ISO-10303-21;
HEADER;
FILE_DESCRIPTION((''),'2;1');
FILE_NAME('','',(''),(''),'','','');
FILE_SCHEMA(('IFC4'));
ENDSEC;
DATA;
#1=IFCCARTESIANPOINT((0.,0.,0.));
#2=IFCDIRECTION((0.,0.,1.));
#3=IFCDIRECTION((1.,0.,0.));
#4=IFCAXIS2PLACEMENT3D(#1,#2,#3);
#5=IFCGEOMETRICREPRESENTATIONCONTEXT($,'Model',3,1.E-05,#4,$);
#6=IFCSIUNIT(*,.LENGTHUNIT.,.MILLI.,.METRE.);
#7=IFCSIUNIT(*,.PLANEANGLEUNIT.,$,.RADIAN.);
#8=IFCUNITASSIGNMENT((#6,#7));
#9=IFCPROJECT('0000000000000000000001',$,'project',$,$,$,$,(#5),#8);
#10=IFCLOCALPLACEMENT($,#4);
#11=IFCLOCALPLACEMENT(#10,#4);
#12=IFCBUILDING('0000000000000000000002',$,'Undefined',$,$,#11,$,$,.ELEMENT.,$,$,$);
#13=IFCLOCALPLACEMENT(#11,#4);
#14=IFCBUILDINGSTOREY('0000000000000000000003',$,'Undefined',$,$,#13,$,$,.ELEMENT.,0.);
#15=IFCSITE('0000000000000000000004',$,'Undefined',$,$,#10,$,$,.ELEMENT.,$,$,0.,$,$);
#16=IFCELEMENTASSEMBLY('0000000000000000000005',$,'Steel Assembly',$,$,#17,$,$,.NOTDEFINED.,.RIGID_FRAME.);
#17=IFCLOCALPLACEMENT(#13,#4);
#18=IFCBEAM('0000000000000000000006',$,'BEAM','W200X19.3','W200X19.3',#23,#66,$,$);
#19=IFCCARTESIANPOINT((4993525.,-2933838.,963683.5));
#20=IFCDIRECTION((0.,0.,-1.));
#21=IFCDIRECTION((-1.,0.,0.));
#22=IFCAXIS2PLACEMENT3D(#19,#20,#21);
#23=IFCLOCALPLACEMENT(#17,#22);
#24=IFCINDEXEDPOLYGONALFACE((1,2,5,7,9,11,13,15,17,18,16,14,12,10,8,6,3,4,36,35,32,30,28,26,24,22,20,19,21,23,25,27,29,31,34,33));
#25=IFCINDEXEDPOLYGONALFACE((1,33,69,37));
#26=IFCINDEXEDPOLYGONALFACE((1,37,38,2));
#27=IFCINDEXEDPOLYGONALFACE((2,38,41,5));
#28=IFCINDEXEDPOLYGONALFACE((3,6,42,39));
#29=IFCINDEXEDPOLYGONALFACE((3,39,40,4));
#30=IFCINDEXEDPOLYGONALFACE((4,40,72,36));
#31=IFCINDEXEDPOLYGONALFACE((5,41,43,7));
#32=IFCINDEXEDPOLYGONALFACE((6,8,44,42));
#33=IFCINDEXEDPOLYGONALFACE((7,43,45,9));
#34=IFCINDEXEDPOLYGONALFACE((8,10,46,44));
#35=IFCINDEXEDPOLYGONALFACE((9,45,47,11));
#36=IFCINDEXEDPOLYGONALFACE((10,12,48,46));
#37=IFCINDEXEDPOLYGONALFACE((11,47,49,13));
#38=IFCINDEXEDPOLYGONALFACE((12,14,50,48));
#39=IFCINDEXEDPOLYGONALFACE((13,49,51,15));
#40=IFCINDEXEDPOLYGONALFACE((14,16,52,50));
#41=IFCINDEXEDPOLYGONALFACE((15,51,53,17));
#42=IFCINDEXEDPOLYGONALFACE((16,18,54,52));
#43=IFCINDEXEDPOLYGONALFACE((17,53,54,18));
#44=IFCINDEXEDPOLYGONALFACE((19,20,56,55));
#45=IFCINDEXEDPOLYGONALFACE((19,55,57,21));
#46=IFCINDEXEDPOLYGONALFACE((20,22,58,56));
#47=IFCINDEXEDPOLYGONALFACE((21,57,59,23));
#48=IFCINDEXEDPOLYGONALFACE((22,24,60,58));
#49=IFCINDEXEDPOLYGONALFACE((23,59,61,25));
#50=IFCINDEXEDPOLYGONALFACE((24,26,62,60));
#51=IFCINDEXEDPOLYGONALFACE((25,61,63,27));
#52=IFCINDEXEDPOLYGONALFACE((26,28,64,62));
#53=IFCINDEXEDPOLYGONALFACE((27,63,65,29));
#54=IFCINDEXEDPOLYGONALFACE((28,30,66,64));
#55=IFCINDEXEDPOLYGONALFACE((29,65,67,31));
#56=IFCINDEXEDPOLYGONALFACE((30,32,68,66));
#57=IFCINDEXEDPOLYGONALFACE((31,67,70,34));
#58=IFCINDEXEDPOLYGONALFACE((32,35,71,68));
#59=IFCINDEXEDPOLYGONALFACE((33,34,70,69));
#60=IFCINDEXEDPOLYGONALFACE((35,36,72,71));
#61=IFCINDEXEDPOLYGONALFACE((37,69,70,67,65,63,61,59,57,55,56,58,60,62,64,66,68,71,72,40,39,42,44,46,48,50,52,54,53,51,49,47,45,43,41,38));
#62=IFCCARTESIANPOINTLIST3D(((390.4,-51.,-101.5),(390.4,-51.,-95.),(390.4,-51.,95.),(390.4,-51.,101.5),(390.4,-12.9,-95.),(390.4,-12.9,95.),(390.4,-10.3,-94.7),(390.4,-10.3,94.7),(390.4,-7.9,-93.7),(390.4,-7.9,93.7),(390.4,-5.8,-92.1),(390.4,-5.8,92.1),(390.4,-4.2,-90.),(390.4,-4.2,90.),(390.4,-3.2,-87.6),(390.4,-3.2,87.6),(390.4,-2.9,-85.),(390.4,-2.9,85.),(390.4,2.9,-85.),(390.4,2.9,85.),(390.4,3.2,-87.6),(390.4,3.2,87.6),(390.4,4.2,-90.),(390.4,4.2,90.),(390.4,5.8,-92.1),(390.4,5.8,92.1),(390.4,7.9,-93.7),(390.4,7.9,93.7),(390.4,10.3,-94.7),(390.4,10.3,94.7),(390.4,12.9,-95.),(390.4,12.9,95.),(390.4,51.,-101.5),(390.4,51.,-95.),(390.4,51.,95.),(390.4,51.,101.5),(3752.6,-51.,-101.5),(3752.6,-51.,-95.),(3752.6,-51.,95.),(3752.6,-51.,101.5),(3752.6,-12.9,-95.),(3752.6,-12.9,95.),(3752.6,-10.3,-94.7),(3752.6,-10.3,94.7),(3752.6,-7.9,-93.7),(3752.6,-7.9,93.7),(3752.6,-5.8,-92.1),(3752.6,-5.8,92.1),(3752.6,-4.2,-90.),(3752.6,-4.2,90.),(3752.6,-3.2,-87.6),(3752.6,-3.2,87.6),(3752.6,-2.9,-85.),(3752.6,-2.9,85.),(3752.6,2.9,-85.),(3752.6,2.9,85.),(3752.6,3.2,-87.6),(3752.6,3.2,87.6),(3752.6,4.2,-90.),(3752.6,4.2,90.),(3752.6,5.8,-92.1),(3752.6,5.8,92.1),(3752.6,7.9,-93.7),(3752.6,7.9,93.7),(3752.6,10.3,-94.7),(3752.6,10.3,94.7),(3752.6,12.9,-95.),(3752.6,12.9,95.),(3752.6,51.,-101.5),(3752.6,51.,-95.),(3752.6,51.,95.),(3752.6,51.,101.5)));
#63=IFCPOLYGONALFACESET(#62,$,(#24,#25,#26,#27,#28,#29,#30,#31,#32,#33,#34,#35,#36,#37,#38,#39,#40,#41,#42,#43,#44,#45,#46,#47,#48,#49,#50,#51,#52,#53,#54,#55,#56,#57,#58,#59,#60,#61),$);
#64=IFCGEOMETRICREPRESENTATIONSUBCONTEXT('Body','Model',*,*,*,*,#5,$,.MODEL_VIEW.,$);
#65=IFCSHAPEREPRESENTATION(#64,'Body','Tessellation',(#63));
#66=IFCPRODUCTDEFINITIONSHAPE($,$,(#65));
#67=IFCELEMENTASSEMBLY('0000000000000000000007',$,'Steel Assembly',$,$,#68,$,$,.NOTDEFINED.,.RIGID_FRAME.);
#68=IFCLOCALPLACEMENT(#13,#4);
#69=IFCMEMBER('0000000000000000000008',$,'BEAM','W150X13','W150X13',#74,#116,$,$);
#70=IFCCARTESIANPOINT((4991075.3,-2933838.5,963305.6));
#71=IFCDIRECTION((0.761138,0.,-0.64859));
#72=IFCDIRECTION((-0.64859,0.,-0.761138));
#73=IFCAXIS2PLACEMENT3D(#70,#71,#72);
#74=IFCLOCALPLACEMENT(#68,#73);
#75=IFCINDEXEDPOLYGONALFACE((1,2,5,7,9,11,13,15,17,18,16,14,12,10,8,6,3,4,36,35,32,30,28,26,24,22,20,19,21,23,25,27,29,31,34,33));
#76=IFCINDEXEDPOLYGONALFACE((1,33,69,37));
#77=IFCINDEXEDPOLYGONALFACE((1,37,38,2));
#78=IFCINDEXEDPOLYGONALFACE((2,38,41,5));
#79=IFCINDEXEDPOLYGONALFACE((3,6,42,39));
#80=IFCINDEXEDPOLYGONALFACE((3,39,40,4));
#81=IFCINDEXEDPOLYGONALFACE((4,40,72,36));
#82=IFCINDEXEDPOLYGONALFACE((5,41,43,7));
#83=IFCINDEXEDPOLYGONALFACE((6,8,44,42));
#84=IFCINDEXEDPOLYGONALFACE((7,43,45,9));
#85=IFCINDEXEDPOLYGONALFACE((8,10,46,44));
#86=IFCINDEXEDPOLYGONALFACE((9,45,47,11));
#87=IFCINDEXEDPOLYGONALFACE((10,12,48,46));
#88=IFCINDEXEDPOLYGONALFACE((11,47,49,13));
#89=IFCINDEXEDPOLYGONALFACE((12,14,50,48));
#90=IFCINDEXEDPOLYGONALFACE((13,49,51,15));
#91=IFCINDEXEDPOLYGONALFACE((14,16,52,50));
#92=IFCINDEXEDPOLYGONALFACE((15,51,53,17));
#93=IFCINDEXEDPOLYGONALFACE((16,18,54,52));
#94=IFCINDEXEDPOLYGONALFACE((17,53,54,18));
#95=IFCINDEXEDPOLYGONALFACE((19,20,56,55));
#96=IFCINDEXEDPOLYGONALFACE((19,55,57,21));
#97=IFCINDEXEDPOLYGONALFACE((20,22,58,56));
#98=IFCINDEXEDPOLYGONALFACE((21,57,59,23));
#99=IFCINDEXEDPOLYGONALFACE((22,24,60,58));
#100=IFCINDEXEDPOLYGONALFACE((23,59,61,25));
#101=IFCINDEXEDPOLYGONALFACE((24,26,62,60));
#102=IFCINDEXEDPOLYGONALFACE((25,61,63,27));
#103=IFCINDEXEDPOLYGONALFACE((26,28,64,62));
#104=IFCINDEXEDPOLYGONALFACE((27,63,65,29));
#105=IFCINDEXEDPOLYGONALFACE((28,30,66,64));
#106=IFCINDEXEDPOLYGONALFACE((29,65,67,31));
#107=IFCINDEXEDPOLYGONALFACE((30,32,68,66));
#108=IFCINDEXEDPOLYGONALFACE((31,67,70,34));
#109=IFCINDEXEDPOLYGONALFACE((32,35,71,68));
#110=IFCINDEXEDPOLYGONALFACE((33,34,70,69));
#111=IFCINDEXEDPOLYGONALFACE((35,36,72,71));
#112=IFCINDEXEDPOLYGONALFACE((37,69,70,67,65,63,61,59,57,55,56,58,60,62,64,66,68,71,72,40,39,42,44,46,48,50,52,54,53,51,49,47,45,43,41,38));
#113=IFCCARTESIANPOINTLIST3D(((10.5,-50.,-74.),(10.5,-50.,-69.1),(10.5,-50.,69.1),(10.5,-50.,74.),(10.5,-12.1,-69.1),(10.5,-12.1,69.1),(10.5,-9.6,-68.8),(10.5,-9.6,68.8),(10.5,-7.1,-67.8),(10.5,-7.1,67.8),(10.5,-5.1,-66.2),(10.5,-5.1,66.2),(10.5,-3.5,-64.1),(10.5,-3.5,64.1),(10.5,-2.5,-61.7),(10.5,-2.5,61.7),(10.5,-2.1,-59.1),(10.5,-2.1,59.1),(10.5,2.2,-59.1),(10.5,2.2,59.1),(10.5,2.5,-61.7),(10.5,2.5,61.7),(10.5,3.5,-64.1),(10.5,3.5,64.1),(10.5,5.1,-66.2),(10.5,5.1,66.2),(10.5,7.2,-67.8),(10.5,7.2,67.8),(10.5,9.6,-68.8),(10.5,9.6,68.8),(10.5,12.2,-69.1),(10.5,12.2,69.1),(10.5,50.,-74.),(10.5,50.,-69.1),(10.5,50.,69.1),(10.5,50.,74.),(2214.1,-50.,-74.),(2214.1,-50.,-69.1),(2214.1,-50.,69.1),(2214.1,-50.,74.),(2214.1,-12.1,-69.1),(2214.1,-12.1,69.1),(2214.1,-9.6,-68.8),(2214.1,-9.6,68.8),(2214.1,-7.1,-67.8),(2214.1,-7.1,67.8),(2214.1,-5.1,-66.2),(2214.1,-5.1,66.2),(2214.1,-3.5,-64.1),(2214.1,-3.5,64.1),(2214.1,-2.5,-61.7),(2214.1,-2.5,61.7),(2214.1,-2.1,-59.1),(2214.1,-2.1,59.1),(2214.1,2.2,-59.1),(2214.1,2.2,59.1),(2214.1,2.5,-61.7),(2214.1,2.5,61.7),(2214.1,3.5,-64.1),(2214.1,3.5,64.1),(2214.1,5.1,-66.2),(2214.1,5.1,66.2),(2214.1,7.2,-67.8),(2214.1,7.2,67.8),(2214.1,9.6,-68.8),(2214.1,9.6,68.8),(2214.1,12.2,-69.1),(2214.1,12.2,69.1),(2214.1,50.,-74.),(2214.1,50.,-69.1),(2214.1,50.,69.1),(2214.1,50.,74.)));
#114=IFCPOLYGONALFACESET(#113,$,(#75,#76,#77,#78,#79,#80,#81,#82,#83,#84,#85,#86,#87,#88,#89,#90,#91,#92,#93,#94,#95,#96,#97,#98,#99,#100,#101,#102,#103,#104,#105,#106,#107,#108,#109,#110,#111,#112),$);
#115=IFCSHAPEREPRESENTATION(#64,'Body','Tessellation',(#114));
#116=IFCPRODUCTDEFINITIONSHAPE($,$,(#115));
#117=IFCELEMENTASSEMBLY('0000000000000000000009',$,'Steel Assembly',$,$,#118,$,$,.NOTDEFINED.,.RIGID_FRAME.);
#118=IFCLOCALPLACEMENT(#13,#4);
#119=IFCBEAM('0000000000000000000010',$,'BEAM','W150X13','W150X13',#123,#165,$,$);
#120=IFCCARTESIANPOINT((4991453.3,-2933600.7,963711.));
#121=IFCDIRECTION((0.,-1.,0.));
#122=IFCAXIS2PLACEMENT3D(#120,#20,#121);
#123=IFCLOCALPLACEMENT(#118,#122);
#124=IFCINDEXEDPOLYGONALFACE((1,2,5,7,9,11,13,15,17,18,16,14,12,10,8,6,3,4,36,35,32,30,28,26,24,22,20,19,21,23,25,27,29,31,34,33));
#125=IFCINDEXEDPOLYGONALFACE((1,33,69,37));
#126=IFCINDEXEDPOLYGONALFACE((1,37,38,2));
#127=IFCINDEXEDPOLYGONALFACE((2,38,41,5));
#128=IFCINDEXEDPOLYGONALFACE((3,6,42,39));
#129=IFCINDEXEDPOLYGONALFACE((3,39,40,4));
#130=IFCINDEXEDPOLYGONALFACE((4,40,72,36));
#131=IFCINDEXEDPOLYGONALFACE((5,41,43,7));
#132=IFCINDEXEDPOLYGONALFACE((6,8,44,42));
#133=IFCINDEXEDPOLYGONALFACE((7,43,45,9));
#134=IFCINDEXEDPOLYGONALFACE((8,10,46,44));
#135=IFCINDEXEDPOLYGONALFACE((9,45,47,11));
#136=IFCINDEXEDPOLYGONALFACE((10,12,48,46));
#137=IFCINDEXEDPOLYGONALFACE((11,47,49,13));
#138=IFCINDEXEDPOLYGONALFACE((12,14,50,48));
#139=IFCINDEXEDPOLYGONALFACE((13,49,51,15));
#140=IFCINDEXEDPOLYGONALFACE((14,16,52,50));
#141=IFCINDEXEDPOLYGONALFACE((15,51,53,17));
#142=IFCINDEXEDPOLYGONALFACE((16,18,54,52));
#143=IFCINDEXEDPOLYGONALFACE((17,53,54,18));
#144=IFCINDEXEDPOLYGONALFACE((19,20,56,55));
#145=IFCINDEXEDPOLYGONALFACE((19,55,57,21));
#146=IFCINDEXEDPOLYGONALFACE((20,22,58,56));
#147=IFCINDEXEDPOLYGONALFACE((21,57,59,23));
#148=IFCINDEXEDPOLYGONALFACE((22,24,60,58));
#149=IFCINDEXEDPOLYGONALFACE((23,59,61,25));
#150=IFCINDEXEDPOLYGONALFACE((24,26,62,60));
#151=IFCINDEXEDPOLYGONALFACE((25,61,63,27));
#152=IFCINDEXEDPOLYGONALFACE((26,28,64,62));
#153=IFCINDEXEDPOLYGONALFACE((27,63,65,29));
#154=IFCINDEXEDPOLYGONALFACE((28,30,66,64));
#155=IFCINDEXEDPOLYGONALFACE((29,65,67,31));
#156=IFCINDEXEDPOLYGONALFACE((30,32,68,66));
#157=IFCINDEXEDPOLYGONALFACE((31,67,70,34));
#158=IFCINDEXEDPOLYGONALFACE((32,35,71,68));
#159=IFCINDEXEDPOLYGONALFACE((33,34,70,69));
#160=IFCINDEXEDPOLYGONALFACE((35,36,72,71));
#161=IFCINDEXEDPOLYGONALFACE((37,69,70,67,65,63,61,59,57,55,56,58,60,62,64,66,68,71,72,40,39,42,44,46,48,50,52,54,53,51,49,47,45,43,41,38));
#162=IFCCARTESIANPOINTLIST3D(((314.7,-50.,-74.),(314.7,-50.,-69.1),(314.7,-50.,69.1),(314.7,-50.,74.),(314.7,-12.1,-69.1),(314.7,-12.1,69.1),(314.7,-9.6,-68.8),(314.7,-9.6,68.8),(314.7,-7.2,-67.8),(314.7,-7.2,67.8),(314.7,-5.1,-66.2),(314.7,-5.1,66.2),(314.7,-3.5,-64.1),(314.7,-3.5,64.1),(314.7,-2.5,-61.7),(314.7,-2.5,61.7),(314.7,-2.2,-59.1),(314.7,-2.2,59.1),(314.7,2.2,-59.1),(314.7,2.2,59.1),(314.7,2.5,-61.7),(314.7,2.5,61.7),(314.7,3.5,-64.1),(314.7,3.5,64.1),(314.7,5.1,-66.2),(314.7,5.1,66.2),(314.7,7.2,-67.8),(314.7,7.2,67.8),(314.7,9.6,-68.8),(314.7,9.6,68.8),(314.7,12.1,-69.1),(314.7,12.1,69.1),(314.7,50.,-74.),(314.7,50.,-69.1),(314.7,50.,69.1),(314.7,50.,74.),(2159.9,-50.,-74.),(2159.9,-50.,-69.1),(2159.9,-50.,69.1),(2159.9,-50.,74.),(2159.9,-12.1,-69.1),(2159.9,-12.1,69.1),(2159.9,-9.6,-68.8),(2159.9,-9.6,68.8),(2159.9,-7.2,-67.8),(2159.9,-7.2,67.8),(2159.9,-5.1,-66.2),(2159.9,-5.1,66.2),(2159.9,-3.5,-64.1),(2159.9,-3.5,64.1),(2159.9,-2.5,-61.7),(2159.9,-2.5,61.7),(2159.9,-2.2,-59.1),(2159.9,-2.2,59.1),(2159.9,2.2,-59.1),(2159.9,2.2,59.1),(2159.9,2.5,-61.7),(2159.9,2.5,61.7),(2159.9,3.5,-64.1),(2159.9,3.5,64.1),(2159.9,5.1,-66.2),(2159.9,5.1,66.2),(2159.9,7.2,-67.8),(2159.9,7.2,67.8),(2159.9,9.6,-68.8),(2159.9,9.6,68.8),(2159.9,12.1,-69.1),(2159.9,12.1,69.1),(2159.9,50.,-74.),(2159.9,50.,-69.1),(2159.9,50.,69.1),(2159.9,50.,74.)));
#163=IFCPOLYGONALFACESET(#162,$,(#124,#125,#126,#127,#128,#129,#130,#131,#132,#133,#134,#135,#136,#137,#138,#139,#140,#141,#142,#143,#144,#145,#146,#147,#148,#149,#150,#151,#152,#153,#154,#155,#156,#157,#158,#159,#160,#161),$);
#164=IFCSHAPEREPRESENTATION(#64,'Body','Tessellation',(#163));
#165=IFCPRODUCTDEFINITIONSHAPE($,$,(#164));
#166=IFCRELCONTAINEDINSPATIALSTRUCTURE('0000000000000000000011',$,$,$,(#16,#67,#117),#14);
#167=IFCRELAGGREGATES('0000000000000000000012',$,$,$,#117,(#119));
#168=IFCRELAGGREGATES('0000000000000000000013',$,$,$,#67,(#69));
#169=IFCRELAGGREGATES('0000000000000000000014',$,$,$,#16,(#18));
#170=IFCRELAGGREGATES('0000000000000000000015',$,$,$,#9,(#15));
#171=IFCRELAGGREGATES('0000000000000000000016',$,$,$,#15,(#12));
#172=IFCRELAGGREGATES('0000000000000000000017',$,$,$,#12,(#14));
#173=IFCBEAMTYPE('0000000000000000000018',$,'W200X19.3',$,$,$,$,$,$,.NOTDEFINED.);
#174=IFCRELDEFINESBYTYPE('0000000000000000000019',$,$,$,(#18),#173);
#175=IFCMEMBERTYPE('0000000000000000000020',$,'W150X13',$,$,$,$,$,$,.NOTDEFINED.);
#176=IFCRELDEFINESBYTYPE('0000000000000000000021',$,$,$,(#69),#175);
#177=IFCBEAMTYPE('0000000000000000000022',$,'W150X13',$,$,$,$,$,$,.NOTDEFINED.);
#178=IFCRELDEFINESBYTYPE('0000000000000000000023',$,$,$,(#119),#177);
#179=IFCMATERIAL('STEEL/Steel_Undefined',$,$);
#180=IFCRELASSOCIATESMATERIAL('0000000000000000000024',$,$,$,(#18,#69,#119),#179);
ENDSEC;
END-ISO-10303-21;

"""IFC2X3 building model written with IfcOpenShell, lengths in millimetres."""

from ifc_helpers import new_model, si_unit, frame, origin_with_axes, origin_2d_with_axis, place, context, subcontext, project, spatial, i_section, extrude, clip, halfspace, material, type_object, element, aggregate, save


model = new_model("IFC2X3")

# Units and contexts
model_context = context("Model", 3, precision=1e-05, world=origin_with_axes())
body_context = subcontext(model_context, "Body", "Model", "MODEL_VIEW")
ifc_project = project(units=[si_unit("LENGTHUNIT", "METRE", prefix="MILLI"), si_unit("PLANEANGLEUNIT", "RADIAN")], contexts=[model_context])

# Site, building, storey
site_placement = place(None, origin_with_axes())
site = spatial("IfcSite", under=ifc_project, at=site_placement, Name="Undefined", CompositionType="ELEMENT", RefElevation=0.0)
building_placement = place(site_placement, origin_with_axes())
building = spatial("IfcBuilding", under=site, at=building_placement, Name="Undefined", CompositionType="ELEMENT")
storey_placement = place(building_placement, origin_with_axes())
storey = spatial("IfcBuildingStorey", under=building, at=storey_placement, Name="Undefined", CompositionType="ELEMENT", Elevation=0.0)

# Element assembly, beam
ifc_material_1 = material(Name="STEEL/Steel_Undefined")
beam_type_1 = type_object("IfcBeamType", Name="W200X19.3", PredefinedType="NOTDEFINED")
assembly_1_placement = place(storey_placement, origin_with_axes())
assembly_1 = element("IfcElementAssembly", 1, at=assembly_1_placement, inside=storey, Name="Steel Assembly", AssemblyPlace="NOTDEFINED", PredefinedType="RIGID_FRAME")
beam_1_placement = place(assembly_1_placement, frame((4993525.0, -2933838.0, 963683.5), z_axis=(0.0, 0.0, -1.0), x_axis=(-1.0, 0.0, 0.0)))
beam_1 = element("IfcBeam", 2, at=beam_1_placement, type_object=beam_type_1, material=ifc_material_1, Name="BEAM", Description="W200X19.3", ObjectType="W200X19.3", context=body_context, shape_type="Clipping", body=[
    clip(clip(extrude(i_section(OverallWidth=102.0, OverallDepth=203.0, WebThickness=5.8, FlangeThickness=6.5, FilletRadius=10.0, at=origin_2d_with_axis()), frame((3752.6, 0.0, 0.0), z_axis=(-1.0, 0.0, 0.0), x_axis=(0.0, -1.0, 0.0)), (0.0, 0.0, 1.0), 3362.2), halfspace(frame((3752.6, 51.0, 0.0), z_axis=(1.0, 0.0, 0.0), x_axis=(0.0, 0.0, -1.0)), False)), halfspace(frame((390.4, -51.0, 0.0), z_axis=(-1.0, 0.0, 0.0), x_axis=(0.0, 0.0, -1.0)), False)),
])

# Element assembly, member
assembly_2_placement = place(storey_placement, origin_with_axes())
assembly_2 = element("IfcElementAssembly", 3, at=assembly_2_placement, inside=storey, Name="Steel Assembly", AssemblyPlace="NOTDEFINED", PredefinedType="RIGID_FRAME")
member_type = type_object("IfcMemberType", Name="W150X13", PredefinedType="NOTDEFINED")
member_placement = place(assembly_2_placement, frame((4991075.3, -2933838.5, 963305.6), z_axis=(0.761138, 0.0, -0.64859), x_axis=(-0.64859, 0.0, -0.761138)))
member = element("IfcMember", 4, at=member_placement, type_object=member_type, material=ifc_material_1, Name="BEAM", Description="W150X13", ObjectType="W150X13", context=body_context, shape_type="Clipping", body=[
    clip(clip(extrude(i_section(OverallWidth=100.0, OverallDepth=148.0, WebThickness=4.3, FlangeThickness=4.9, FilletRadius=10.0, at=origin_2d_with_axis()), frame((2361.7, 0.0, 0.0), z_axis=(-1.0, 0.0, 0.0), x_axis=(0.0, -1.0, 0.0)), (0.0, 0.0, 1.0), 2498.7), halfspace(frame((2214.1, 0.0, -74.0), z_axis=(-1.0, 0.0, 0.0), x_axis=(0.0, 1.0, 0.0)), True)), halfspace(frame((10.5, 0.0, -74.0), z_axis=(1.0, 0.0, 0.0), x_axis=(0.0, -1.0, 0.0)), True)),
])

# Element assembly, beam
assembly_3_placement = place(storey_placement, origin_with_axes())
assembly_3 = element("IfcElementAssembly", 5, at=assembly_3_placement, inside=storey, Name="Steel Assembly", AssemblyPlace="NOTDEFINED", PredefinedType="RIGID_FRAME")
beam_type_2 = type_object("IfcBeamType", Name="W150X13", PredefinedType="NOTDEFINED")
beam_2_placement = place(assembly_3_placement, frame((4991453.3, -2933600.7, 963711.0), z_axis=(0.0, 0.0, -1.0), x_axis=(0.0, -1.0, 0.0)))
beam_2 = element("IfcBeam", 6, at=beam_2_placement, type_object=beam_type_2, material=ifc_material_1, Name="BEAM", Description="W150X13", ObjectType="W150X13", context=body_context, shape_type="Clipping", body=[
    clip(clip(clip(clip(extrude(i_section(OverallWidth=100.0, OverallDepth=148.0, WebThickness=4.3, FlangeThickness=4.9, FilletRadius=10.0, at=origin_2d_with_axis()), frame((2159.9, 0.0, 0.0), z_axis=(-1.0, 0.0, 0.0), x_axis=(0.0, -1.0, 0.0)), (0.0, 0.0, 1.0), 1845.2), halfspace(frame((313.7, -50.0, 74.0), z_axis=(-1.0, 0.0, 0.0), x_axis=(0.0, 0.0, -1.0)), False)), halfspace(frame((2160.9, 50.0, 74.0), z_axis=(1.0, 0.0, 0.0), x_axis=(0.0, 0.0, -1.0)), False)), halfspace(frame((2159.9, 0.0, -74.0), z_axis=(-1.0, 0.0, 0.0), x_axis=(0.0, 1.0, 0.0)), True)), halfspace(frame((314.7, 0.0, -74.0), z_axis=(1.0, 0.0, 0.0), x_axis=(0.0, -1.0, 0.0)), True)),
])
aggregate(assembly_3, [beam_2])

aggregate(assembly_2, [member])

aggregate(assembly_1, [beam_1])

save(model, "model.ifc")
